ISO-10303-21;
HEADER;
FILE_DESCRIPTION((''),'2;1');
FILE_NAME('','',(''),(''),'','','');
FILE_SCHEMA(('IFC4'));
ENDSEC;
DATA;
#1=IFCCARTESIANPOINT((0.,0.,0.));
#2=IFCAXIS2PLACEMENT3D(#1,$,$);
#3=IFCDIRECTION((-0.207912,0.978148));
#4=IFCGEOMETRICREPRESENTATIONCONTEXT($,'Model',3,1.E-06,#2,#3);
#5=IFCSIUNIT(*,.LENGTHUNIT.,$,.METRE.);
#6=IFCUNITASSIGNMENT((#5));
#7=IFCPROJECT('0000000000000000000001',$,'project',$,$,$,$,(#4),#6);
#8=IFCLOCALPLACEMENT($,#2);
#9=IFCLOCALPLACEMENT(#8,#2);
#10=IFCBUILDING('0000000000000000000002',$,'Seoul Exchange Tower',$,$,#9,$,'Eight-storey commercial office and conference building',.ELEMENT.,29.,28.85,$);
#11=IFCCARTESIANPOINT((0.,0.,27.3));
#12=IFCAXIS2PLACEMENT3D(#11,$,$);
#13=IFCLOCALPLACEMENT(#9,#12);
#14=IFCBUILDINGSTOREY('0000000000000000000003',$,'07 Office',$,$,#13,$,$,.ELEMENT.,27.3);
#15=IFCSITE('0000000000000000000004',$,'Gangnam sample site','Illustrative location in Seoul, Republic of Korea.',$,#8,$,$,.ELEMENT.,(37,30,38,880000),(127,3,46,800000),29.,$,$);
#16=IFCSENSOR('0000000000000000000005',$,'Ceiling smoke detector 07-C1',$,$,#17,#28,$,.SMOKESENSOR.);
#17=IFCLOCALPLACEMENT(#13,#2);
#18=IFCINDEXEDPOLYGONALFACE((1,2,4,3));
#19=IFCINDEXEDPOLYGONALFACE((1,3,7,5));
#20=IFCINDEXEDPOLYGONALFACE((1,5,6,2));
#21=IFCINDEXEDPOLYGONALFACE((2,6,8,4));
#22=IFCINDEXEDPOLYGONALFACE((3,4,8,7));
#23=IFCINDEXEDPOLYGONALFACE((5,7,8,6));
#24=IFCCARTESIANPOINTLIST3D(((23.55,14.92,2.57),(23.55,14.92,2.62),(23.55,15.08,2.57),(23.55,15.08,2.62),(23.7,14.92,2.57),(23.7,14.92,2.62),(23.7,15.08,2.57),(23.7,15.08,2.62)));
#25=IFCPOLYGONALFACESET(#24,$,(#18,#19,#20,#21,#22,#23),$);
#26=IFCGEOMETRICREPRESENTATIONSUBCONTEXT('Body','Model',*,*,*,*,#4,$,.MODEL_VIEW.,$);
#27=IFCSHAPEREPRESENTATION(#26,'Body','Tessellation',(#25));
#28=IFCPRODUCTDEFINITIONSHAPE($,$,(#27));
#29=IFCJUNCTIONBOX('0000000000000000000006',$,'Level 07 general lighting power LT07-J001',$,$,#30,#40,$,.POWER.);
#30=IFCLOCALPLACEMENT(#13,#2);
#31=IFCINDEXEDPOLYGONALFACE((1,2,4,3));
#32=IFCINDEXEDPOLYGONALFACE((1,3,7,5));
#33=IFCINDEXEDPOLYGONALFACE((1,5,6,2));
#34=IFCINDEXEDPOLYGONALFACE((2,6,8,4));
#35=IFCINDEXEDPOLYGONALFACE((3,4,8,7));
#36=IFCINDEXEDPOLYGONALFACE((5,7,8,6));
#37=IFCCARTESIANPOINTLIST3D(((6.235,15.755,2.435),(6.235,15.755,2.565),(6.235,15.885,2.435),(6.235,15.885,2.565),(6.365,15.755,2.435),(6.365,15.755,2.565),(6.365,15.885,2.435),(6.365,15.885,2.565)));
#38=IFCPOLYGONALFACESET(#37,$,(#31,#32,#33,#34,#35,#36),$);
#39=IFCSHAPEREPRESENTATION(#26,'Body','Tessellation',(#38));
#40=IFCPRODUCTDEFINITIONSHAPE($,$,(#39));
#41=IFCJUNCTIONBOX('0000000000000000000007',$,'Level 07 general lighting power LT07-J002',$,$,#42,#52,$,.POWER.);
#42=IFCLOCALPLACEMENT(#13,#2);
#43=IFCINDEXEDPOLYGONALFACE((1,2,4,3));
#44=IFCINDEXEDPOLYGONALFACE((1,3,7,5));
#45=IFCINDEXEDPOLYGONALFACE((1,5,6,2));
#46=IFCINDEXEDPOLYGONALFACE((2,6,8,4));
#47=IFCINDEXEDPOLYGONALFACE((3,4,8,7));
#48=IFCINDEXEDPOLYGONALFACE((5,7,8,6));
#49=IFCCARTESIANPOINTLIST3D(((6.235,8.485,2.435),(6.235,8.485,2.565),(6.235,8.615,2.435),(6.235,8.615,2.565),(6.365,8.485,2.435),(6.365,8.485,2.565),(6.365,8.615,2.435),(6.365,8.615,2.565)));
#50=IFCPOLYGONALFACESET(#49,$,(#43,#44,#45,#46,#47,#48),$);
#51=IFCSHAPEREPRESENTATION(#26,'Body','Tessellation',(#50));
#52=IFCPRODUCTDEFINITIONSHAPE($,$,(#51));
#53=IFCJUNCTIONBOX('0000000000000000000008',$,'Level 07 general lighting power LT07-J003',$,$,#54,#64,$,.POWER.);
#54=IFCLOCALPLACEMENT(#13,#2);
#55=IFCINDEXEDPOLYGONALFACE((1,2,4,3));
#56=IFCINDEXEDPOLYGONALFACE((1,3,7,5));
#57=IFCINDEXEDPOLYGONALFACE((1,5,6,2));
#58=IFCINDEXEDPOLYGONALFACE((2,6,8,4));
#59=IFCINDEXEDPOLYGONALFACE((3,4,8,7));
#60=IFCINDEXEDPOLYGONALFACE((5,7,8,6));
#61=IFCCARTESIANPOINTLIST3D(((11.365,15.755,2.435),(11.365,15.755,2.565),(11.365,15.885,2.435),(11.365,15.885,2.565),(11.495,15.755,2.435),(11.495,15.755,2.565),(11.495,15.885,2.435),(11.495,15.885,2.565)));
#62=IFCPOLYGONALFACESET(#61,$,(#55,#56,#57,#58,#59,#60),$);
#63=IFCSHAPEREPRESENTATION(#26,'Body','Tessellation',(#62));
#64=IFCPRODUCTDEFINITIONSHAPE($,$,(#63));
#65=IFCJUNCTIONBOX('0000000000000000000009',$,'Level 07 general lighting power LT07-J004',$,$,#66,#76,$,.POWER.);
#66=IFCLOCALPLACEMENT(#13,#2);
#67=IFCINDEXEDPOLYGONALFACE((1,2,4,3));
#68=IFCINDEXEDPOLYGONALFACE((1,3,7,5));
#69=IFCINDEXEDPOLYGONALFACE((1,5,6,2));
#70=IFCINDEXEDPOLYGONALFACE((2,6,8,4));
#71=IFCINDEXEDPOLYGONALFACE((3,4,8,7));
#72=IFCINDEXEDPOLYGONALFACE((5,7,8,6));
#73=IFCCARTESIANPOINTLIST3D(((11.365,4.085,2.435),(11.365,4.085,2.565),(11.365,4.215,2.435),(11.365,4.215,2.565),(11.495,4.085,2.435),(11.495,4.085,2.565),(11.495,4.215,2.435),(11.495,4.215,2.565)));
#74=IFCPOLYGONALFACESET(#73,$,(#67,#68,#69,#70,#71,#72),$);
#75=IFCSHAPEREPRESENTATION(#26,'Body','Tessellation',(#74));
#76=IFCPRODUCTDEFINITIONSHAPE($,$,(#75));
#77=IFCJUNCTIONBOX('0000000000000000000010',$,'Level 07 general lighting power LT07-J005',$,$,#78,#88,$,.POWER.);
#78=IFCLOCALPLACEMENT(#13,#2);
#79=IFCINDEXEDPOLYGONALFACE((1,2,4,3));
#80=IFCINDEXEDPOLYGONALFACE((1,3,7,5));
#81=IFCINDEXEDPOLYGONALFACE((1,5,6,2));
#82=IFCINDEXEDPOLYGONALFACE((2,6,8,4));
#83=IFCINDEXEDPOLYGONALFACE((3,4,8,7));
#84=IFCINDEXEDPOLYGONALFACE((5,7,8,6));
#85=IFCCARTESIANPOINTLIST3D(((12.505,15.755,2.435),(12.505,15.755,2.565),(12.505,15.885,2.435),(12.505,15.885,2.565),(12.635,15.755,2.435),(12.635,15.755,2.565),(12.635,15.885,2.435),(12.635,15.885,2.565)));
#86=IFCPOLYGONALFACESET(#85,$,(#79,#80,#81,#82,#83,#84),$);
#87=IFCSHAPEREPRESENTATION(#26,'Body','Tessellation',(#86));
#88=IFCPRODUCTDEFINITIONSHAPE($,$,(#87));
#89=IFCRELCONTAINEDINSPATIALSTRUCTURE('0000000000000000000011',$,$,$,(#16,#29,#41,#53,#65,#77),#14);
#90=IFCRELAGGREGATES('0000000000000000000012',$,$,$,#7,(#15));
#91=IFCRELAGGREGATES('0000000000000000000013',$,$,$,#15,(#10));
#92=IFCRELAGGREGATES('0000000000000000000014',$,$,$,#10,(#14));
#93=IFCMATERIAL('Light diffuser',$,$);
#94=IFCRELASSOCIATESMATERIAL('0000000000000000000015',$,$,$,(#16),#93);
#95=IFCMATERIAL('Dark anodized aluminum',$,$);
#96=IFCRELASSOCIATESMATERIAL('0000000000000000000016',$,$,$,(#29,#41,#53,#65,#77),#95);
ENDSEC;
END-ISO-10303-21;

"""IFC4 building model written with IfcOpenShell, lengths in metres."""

from ifc_helpers import new_model, si_unit, direction, frame, frame_2d, origin, place, context, subcontext, project, spatial, rectangle, extrude, material, element, save


model = new_model("IFC4")

# Units and contexts
model_context = context("Model", 3, precision=1e-06, world=origin(), true_north=direction((-0.207912, 0.978148)))
body_context = subcontext(model_context, "Body", "Model", "MODEL_VIEW")
ifc_project = project(units=[si_unit("LENGTHUNIT", "METRE")], contexts=[model_context])

# Site, building, storey
site_placement = place(None, origin())
site = spatial("IfcSite", under=ifc_project, at=site_placement, Name="Gangnam sample site", Description="Illustrative location in Seoul, Republic of Korea.", CompositionType="ELEMENT", RefLatitude=(37, 30, 38, 880000), RefLongitude=(127, 3, 46, 800000), RefElevation=29.0)
building_placement = place(site_placement, origin())
building = spatial("IfcBuilding", under=site, at=building_placement, Name="Seoul Exchange Tower", LongName="Eight-storey commercial office and conference building", CompositionType="ELEMENT", ElevationOfRefHeight=29.0, ElevationOfTerrain=28.85)
storey_placement = place(building_placement, frame((0.0, 0.0, 27.3)))
storey = spatial("IfcBuildingStorey", under=building, at=storey_placement, Name="07 Office", CompositionType="ELEMENT", Elevation=27.3)

# Shared definitions
placement = place(storey_placement, origin())

# Shared definitions
ifc_material_1 = material(Name="Light diffuser")

# Sensor
element("IfcSensor", 1, at=placement, inside=storey, material=ifc_material_1, Name="Ceiling smoke detector 07-C1", PredefinedType="SMOKESENSOR", context=body_context, shape_type="SweptSolid", body=[
    extrude(rectangle(XDim=0.15, YDim=0.16, at=frame_2d((0.075, 0.08))), frame((23.55, 14.92, 2.57)), (0.0, 0.0, 1.0), 0.05),
])

# Junction boxes
ifc_material_2 = material(Name="Dark anodized aluminum")
element("IfcJunctionBox", 2, at=placement, inside=storey, material=ifc_material_2, Name="Level 07 general lighting power LT07-J001", PredefinedType="POWER", context=body_context, shape_type="SweptSolid", body=[
    extrude(rectangle(XDim=0.13, YDim=0.13, at=frame_2d((0.065, 0.065))), frame((6.235, 15.755, 2.435)), (0.0, 0.0, 1.0), 0.13),
])
element("IfcJunctionBox", 3, at=placement, inside=storey, material=ifc_material_2, Name="Level 07 general lighting power LT07-J002", PredefinedType="POWER", context=body_context, shape_type="SweptSolid", body=[
    extrude(rectangle(XDim=0.13, YDim=0.13, at=frame_2d((0.065, 0.065))), frame((6.235, 8.485, 2.435)), (0.0, 0.0, 1.0), 0.13),
])
element("IfcJunctionBox", 4, at=placement, inside=storey, material=ifc_material_2, Name="Level 07 general lighting power LT07-J003", PredefinedType="POWER", context=body_context, shape_type="SweptSolid", body=[
    extrude(rectangle(XDim=0.13, YDim=0.13, at=frame_2d((0.065, 0.065))), frame((11.365, 15.755, 2.435)), (0.0, 0.0, 1.0), 0.13),
])
element("IfcJunctionBox", 5, at=placement, inside=storey, material=ifc_material_2, Name="Level 07 general lighting power LT07-J004", PredefinedType="POWER", context=body_context, shape_type="SweptSolid", body=[
    extrude(rectangle(XDim=0.13, YDim=0.13, at=frame_2d((0.065, 0.065))), frame((11.365, 4.085, 2.435)), (0.0, 0.0, 1.0), 0.13),
])
element("IfcJunctionBox", 6, at=placement, inside=storey, material=ifc_material_2, Name="Level 07 general lighting power LT07-J005", PredefinedType="POWER", context=body_context, shape_type="SweptSolid", body=[
    extrude(rectangle(XDim=0.13, YDim=0.13, at=frame_2d((0.065, 0.065))), frame((12.505, 15.755, 2.435)), (0.0, 0.0, 1.0), 0.13),
])

save(model, "model.ifc")
